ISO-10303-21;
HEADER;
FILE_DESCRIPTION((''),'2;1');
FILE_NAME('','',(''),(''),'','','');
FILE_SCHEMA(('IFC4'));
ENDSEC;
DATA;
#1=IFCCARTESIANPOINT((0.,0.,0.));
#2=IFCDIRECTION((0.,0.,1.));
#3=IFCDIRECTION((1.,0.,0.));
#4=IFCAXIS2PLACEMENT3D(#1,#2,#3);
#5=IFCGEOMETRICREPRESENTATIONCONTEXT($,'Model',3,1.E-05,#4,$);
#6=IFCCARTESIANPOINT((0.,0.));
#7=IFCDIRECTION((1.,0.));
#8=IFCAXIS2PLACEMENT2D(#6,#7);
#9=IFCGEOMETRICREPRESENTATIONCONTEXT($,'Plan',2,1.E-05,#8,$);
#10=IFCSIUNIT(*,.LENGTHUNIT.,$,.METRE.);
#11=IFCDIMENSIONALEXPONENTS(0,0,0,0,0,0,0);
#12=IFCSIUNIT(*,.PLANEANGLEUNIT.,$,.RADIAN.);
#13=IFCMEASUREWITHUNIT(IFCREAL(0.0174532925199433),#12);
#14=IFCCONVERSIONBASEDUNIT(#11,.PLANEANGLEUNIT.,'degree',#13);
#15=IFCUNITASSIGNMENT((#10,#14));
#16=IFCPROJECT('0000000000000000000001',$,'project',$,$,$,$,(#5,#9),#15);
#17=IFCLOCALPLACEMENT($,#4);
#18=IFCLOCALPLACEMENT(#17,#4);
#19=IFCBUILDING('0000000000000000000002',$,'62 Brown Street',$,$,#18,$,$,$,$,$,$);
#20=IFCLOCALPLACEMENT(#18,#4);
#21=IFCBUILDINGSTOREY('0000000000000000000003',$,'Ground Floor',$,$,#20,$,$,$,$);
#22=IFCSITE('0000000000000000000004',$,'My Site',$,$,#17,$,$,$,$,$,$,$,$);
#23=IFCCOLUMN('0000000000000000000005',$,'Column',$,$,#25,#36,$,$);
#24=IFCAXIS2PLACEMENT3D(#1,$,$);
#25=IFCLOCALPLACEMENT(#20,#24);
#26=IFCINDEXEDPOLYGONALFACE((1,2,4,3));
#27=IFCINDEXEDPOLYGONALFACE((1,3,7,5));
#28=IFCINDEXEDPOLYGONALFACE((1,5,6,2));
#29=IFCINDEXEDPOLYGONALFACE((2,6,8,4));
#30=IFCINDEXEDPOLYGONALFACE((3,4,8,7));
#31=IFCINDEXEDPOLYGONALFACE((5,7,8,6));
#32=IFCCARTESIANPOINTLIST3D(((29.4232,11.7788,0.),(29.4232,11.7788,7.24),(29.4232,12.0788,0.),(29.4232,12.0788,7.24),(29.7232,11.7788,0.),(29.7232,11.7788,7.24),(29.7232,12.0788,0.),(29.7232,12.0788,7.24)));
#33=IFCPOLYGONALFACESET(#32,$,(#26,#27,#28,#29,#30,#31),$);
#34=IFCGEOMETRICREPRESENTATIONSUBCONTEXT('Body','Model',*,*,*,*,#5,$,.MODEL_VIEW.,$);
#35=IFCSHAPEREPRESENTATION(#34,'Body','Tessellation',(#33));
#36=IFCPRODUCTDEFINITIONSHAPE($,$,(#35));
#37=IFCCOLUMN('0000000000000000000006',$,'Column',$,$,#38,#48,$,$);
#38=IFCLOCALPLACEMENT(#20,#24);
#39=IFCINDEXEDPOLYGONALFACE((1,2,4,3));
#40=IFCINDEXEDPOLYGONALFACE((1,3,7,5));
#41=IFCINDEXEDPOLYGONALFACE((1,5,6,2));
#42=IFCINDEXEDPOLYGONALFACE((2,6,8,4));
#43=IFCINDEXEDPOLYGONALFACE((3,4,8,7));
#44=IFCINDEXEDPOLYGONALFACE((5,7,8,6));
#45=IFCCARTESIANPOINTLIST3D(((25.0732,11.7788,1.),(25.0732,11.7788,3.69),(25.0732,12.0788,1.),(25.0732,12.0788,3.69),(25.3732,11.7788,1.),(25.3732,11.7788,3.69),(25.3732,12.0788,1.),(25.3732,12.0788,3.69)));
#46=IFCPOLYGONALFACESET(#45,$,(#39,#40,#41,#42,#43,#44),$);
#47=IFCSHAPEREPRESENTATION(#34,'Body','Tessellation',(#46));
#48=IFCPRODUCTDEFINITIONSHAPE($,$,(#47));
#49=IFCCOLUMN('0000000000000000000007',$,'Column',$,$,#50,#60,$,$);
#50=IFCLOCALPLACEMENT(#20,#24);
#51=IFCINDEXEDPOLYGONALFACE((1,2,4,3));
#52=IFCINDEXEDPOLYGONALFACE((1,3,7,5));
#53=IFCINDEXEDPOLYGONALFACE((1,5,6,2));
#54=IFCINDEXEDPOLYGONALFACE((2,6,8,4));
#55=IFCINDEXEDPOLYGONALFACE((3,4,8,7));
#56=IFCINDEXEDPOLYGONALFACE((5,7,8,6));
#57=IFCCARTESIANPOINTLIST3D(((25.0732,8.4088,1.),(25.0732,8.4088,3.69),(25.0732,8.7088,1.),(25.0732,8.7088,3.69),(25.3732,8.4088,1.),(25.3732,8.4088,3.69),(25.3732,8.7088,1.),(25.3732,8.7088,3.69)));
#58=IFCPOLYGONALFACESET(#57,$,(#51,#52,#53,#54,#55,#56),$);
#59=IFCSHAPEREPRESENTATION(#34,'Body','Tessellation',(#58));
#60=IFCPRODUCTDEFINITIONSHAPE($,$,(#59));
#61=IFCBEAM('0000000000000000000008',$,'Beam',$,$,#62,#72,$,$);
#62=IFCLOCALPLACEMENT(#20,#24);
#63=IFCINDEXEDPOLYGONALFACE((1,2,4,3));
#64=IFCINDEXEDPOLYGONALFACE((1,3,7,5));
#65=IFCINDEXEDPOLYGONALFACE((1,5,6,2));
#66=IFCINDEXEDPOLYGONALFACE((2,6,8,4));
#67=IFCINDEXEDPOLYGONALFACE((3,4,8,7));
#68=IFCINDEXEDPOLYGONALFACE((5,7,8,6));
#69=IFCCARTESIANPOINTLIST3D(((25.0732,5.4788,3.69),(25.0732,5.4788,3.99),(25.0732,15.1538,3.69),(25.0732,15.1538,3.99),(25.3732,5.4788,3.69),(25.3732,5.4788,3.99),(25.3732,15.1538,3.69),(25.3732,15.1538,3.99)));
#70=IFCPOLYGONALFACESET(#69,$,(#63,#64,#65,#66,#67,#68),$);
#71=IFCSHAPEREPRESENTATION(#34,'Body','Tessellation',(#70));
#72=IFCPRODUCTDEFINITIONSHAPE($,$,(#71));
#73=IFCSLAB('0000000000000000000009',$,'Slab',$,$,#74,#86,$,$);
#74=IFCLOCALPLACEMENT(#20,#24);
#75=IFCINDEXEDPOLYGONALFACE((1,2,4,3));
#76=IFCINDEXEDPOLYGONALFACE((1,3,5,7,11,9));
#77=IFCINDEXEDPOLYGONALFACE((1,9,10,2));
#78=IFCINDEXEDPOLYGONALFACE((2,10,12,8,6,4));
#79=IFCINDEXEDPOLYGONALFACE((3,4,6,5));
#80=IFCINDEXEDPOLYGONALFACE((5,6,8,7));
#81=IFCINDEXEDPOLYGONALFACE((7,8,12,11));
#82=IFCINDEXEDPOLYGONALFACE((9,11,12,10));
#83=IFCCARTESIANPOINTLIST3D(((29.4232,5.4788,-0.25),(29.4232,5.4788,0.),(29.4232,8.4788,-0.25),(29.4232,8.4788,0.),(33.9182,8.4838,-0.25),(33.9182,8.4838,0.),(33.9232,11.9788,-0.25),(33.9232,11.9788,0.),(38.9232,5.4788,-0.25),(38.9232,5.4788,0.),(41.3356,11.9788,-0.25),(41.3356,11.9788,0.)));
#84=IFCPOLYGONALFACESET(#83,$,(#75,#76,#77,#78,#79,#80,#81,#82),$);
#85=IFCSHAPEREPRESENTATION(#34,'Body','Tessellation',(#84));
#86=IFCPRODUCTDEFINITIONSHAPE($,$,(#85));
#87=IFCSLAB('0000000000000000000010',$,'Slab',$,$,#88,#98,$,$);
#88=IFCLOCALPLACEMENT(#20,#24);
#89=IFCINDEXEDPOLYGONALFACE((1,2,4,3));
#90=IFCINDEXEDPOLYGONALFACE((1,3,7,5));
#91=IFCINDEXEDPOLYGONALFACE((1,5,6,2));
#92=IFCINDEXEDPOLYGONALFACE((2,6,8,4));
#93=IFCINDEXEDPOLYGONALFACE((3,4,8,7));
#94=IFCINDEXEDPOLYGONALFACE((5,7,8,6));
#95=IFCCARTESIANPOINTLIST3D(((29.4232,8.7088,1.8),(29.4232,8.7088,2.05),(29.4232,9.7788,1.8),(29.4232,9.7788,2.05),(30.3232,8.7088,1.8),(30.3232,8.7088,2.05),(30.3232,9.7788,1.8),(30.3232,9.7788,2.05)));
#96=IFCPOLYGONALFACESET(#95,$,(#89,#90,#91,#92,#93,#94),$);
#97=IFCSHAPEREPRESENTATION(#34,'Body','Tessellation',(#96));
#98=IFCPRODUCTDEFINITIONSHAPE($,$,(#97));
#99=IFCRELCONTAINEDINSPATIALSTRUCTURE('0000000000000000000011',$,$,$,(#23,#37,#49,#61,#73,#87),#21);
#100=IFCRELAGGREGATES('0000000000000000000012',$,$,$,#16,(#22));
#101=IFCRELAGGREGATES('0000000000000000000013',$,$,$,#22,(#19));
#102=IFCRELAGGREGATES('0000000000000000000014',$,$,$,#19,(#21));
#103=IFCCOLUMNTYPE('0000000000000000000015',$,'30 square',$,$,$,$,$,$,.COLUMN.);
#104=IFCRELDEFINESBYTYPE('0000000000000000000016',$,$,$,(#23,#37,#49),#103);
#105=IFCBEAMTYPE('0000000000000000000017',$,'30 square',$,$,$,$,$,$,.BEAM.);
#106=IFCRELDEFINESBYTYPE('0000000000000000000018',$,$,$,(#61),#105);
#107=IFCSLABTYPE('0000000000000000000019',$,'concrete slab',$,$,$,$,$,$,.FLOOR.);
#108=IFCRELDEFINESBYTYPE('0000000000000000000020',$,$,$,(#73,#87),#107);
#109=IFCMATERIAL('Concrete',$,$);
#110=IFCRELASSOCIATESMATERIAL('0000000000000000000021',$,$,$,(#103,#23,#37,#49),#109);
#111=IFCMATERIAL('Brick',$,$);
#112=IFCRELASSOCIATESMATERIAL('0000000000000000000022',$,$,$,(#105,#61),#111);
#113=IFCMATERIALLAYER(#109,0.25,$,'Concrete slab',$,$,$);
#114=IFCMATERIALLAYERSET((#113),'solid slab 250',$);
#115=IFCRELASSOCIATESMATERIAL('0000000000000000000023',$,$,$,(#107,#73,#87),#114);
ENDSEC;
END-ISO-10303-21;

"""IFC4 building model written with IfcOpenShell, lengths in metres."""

from ifc_helpers import new_model, entity, si_unit, converted_unit, frame, origin_with_axes, origin_2d_with_axis, place, context, subcontext, project, spatial, line, indexed_curve, rectangle, outline, extrude, material, layer, layer_set, layer_usage, material_profile, profile_set, profile_usage, type_object, element, save


model = new_model("IFC4")

# Units and contexts
model_context = context("Model", 3, precision=1e-05, world=origin_with_axes())
plan_context = context("Plan", 2, precision=1e-05, world=origin_2d_with_axis())
body_context_1 = subcontext(model_context, "Body", "Model", "MODEL_VIEW")
ifc_project = project(units=[si_unit("LENGTHUNIT", "METRE"), converted_unit("PLANEANGLEUNIT", "degree", entity("IfcReal", 0.0174532925199433), si_unit("PLANEANGLEUNIT", "RADIAN"), dimensions=[0, 0, 0, 0, 0, 0, 0])], contexts=[model_context, plan_context])

# Site, building, storey
site_placement = place(None, origin_with_axes())
site = spatial("IfcSite", under=ifc_project, at=site_placement, Name="My Site")
building_placement = place(site_placement, origin_with_axes())
building = spatial("IfcBuilding", under=site, at=building_placement, Name="62 Brown Street")
storey_placement = place(building_placement, origin_with_axes())
storey = spatial("IfcBuildingStorey", under=building, at=storey_placement, Name="Ground Floor")

# Columns
ifc_material_1 = material(Name="Concrete")
ifc_material_profile_1 = material_profile(ifc_material_1, rectangle(XDim=0.3, YDim=0.3))
ifc_profile_set_1 = profile_set([ifc_material_profile_1])
ifc_profile_usage_1 = profile_usage(ifc_profile_set_1, cardinal=5)
column_type = type_object("IfcColumnType", Name="30 square", PredefinedType="COLUMN", material=ifc_profile_set_1)
column_1_placement = place(storey_placement, frame((29.5732, 11.9288, 0.0), z_axis=(0.0, 0.0, 1.0), x_axis=(1.0, 0.0, 0.0)))
element("IfcColumn", 1, at=column_1_placement, inside=storey, type_object=column_type, material=ifc_profile_usage_1, Name="Column", context=body_context_1, shape_type="SweptSolid", body=[
    extrude(rectangle(XDim=0.3, YDim=0.3), origin_with_axes(), (0.0, 0.0, 1.0), 7.24),
])
ifc_profile_usage_2 = profile_usage(ifc_profile_set_1, cardinal=5)
column_2_placement = place(storey_placement, frame((25.2232, 11.9288, 1.0), z_axis=(0.0, 0.0, 1.0), x_axis=(1.0, 0.0, 0.0)))
element("IfcColumn", 2, at=column_2_placement, inside=storey, type_object=column_type, material=ifc_profile_usage_2, Name="Column", context=body_context_1, shape_type="SweptSolid", body=[
    extrude(rectangle(XDim=0.3, YDim=0.3), origin_with_axes(), (0.0, 0.0, 1.0), 2.69),
])
ifc_profile_usage_3 = profile_usage(ifc_profile_set_1, cardinal=5)
column_3_placement = place(storey_placement, frame((25.2232, 8.5588, 1.0), z_axis=(0.0, 0.0, 1.0), x_axis=(1.0, 0.0, 0.0)))
element("IfcColumn", 3, at=column_3_placement, inside=storey, type_object=column_type, material=ifc_profile_usage_3, Name="Column", context=body_context_1, shape_type="SweptSolid", body=[
    extrude(rectangle(XDim=0.3, YDim=0.3), origin_with_axes(), (0.0, 0.0, 1.0), 2.69),
])

# Beam
ifc_material_2 = material(Name="Brick")
ifc_material_profile_2 = material_profile(ifc_material_2, rectangle(XDim=0.3, YDim=0.3))
ifc_profile_set_2 = profile_set([ifc_material_profile_2])
ifc_profile_usage_4 = profile_usage(ifc_profile_set_2, cardinal=5)
beam_type = type_object("IfcBeamType", Name="30 square", PredefinedType="BEAM", material=ifc_profile_set_2)
beam_placement = place(storey_placement, frame((25.2232, 5.4788, 3.84), z_axis=(0.0, 1.0, 0.0), x_axis=(-1.0, 0.0, 0.0)))
element("IfcBeam", 4, at=beam_placement, inside=storey, type_object=beam_type, material=ifc_profile_usage_4, Name="Beam", context=body_context_1, shape_type="SweptSolid", body=[
    extrude(rectangle(XDim=0.3, YDim=0.3), origin_with_axes(), (0.0, 0.0, 1.0), 9.675),
])

# Slabs
ifc_layer_1 = layer(ifc_material_1, 0.25, Name="Concrete slab")
ifc_layer_set_1 = layer_set([ifc_layer_1], Name="solid slab 250")
ifc_layer_usage_1 = layer_usage(ifc_layer_set_1, "AXIS3", "POSITIVE", 0.0)
slab_type = type_object("IfcSlabType", Name="concrete slab", PredefinedType="FLOOR", material=ifc_layer_set_1)
slab_1_placement = place(storey_placement, frame((29.4232, 5.4788, -0.25), z_axis=(0.0, 0.0, 1.0), x_axis=(1.0, 0.0, 0.0)))
element("IfcSlab", 5, at=slab_1_placement, inside=storey, type_object=slab_type, material=ifc_layer_usage_1, Name="Slab", context=body_context_1, shape_type="SweptSolid", body=[
    extrude(outline(indexed_curve([(0.0, 0.0), (9.5, 0.0), (11.9124, 6.5), (0.0, 3.0), (4.5, 6.5), (4.495, 3.005)], segments=[line(1, 2), line(2, 3), line(3, 5), line(5, 6), line(6, 4), line(4, 1)], self_intersect=False)), None, (0.0, 0.0, 1.0), 0.25),
])
ifc_layer_usage_2 = layer_usage(ifc_layer_set_1, "AXIS3", "POSITIVE", 0.0)
slab_2_placement = place(storey_placement, frame((29.4232, 8.7088, 1.8), z_axis=(0.0, 0.0, 1.0), x_axis=(1.0, 0.0, 0.0)))
element("IfcSlab", 6, at=slab_2_placement, inside=storey, type_object=slab_type, material=ifc_layer_usage_2, Name="Slab", context=body_context_1, shape_type="SweptSolid", body=[
    extrude(outline(indexed_curve([(0.9, 1.07), (0.9, 0.0), (0.0, 0.0), (0.0, 1.07)], segments=[line(3, 2), line(2, 1), line(1, 4), line(4, 3)], self_intersect=False)), None, (0.0, 0.0, 1.0), 0.25),
])

save(model, "model.ifc")
